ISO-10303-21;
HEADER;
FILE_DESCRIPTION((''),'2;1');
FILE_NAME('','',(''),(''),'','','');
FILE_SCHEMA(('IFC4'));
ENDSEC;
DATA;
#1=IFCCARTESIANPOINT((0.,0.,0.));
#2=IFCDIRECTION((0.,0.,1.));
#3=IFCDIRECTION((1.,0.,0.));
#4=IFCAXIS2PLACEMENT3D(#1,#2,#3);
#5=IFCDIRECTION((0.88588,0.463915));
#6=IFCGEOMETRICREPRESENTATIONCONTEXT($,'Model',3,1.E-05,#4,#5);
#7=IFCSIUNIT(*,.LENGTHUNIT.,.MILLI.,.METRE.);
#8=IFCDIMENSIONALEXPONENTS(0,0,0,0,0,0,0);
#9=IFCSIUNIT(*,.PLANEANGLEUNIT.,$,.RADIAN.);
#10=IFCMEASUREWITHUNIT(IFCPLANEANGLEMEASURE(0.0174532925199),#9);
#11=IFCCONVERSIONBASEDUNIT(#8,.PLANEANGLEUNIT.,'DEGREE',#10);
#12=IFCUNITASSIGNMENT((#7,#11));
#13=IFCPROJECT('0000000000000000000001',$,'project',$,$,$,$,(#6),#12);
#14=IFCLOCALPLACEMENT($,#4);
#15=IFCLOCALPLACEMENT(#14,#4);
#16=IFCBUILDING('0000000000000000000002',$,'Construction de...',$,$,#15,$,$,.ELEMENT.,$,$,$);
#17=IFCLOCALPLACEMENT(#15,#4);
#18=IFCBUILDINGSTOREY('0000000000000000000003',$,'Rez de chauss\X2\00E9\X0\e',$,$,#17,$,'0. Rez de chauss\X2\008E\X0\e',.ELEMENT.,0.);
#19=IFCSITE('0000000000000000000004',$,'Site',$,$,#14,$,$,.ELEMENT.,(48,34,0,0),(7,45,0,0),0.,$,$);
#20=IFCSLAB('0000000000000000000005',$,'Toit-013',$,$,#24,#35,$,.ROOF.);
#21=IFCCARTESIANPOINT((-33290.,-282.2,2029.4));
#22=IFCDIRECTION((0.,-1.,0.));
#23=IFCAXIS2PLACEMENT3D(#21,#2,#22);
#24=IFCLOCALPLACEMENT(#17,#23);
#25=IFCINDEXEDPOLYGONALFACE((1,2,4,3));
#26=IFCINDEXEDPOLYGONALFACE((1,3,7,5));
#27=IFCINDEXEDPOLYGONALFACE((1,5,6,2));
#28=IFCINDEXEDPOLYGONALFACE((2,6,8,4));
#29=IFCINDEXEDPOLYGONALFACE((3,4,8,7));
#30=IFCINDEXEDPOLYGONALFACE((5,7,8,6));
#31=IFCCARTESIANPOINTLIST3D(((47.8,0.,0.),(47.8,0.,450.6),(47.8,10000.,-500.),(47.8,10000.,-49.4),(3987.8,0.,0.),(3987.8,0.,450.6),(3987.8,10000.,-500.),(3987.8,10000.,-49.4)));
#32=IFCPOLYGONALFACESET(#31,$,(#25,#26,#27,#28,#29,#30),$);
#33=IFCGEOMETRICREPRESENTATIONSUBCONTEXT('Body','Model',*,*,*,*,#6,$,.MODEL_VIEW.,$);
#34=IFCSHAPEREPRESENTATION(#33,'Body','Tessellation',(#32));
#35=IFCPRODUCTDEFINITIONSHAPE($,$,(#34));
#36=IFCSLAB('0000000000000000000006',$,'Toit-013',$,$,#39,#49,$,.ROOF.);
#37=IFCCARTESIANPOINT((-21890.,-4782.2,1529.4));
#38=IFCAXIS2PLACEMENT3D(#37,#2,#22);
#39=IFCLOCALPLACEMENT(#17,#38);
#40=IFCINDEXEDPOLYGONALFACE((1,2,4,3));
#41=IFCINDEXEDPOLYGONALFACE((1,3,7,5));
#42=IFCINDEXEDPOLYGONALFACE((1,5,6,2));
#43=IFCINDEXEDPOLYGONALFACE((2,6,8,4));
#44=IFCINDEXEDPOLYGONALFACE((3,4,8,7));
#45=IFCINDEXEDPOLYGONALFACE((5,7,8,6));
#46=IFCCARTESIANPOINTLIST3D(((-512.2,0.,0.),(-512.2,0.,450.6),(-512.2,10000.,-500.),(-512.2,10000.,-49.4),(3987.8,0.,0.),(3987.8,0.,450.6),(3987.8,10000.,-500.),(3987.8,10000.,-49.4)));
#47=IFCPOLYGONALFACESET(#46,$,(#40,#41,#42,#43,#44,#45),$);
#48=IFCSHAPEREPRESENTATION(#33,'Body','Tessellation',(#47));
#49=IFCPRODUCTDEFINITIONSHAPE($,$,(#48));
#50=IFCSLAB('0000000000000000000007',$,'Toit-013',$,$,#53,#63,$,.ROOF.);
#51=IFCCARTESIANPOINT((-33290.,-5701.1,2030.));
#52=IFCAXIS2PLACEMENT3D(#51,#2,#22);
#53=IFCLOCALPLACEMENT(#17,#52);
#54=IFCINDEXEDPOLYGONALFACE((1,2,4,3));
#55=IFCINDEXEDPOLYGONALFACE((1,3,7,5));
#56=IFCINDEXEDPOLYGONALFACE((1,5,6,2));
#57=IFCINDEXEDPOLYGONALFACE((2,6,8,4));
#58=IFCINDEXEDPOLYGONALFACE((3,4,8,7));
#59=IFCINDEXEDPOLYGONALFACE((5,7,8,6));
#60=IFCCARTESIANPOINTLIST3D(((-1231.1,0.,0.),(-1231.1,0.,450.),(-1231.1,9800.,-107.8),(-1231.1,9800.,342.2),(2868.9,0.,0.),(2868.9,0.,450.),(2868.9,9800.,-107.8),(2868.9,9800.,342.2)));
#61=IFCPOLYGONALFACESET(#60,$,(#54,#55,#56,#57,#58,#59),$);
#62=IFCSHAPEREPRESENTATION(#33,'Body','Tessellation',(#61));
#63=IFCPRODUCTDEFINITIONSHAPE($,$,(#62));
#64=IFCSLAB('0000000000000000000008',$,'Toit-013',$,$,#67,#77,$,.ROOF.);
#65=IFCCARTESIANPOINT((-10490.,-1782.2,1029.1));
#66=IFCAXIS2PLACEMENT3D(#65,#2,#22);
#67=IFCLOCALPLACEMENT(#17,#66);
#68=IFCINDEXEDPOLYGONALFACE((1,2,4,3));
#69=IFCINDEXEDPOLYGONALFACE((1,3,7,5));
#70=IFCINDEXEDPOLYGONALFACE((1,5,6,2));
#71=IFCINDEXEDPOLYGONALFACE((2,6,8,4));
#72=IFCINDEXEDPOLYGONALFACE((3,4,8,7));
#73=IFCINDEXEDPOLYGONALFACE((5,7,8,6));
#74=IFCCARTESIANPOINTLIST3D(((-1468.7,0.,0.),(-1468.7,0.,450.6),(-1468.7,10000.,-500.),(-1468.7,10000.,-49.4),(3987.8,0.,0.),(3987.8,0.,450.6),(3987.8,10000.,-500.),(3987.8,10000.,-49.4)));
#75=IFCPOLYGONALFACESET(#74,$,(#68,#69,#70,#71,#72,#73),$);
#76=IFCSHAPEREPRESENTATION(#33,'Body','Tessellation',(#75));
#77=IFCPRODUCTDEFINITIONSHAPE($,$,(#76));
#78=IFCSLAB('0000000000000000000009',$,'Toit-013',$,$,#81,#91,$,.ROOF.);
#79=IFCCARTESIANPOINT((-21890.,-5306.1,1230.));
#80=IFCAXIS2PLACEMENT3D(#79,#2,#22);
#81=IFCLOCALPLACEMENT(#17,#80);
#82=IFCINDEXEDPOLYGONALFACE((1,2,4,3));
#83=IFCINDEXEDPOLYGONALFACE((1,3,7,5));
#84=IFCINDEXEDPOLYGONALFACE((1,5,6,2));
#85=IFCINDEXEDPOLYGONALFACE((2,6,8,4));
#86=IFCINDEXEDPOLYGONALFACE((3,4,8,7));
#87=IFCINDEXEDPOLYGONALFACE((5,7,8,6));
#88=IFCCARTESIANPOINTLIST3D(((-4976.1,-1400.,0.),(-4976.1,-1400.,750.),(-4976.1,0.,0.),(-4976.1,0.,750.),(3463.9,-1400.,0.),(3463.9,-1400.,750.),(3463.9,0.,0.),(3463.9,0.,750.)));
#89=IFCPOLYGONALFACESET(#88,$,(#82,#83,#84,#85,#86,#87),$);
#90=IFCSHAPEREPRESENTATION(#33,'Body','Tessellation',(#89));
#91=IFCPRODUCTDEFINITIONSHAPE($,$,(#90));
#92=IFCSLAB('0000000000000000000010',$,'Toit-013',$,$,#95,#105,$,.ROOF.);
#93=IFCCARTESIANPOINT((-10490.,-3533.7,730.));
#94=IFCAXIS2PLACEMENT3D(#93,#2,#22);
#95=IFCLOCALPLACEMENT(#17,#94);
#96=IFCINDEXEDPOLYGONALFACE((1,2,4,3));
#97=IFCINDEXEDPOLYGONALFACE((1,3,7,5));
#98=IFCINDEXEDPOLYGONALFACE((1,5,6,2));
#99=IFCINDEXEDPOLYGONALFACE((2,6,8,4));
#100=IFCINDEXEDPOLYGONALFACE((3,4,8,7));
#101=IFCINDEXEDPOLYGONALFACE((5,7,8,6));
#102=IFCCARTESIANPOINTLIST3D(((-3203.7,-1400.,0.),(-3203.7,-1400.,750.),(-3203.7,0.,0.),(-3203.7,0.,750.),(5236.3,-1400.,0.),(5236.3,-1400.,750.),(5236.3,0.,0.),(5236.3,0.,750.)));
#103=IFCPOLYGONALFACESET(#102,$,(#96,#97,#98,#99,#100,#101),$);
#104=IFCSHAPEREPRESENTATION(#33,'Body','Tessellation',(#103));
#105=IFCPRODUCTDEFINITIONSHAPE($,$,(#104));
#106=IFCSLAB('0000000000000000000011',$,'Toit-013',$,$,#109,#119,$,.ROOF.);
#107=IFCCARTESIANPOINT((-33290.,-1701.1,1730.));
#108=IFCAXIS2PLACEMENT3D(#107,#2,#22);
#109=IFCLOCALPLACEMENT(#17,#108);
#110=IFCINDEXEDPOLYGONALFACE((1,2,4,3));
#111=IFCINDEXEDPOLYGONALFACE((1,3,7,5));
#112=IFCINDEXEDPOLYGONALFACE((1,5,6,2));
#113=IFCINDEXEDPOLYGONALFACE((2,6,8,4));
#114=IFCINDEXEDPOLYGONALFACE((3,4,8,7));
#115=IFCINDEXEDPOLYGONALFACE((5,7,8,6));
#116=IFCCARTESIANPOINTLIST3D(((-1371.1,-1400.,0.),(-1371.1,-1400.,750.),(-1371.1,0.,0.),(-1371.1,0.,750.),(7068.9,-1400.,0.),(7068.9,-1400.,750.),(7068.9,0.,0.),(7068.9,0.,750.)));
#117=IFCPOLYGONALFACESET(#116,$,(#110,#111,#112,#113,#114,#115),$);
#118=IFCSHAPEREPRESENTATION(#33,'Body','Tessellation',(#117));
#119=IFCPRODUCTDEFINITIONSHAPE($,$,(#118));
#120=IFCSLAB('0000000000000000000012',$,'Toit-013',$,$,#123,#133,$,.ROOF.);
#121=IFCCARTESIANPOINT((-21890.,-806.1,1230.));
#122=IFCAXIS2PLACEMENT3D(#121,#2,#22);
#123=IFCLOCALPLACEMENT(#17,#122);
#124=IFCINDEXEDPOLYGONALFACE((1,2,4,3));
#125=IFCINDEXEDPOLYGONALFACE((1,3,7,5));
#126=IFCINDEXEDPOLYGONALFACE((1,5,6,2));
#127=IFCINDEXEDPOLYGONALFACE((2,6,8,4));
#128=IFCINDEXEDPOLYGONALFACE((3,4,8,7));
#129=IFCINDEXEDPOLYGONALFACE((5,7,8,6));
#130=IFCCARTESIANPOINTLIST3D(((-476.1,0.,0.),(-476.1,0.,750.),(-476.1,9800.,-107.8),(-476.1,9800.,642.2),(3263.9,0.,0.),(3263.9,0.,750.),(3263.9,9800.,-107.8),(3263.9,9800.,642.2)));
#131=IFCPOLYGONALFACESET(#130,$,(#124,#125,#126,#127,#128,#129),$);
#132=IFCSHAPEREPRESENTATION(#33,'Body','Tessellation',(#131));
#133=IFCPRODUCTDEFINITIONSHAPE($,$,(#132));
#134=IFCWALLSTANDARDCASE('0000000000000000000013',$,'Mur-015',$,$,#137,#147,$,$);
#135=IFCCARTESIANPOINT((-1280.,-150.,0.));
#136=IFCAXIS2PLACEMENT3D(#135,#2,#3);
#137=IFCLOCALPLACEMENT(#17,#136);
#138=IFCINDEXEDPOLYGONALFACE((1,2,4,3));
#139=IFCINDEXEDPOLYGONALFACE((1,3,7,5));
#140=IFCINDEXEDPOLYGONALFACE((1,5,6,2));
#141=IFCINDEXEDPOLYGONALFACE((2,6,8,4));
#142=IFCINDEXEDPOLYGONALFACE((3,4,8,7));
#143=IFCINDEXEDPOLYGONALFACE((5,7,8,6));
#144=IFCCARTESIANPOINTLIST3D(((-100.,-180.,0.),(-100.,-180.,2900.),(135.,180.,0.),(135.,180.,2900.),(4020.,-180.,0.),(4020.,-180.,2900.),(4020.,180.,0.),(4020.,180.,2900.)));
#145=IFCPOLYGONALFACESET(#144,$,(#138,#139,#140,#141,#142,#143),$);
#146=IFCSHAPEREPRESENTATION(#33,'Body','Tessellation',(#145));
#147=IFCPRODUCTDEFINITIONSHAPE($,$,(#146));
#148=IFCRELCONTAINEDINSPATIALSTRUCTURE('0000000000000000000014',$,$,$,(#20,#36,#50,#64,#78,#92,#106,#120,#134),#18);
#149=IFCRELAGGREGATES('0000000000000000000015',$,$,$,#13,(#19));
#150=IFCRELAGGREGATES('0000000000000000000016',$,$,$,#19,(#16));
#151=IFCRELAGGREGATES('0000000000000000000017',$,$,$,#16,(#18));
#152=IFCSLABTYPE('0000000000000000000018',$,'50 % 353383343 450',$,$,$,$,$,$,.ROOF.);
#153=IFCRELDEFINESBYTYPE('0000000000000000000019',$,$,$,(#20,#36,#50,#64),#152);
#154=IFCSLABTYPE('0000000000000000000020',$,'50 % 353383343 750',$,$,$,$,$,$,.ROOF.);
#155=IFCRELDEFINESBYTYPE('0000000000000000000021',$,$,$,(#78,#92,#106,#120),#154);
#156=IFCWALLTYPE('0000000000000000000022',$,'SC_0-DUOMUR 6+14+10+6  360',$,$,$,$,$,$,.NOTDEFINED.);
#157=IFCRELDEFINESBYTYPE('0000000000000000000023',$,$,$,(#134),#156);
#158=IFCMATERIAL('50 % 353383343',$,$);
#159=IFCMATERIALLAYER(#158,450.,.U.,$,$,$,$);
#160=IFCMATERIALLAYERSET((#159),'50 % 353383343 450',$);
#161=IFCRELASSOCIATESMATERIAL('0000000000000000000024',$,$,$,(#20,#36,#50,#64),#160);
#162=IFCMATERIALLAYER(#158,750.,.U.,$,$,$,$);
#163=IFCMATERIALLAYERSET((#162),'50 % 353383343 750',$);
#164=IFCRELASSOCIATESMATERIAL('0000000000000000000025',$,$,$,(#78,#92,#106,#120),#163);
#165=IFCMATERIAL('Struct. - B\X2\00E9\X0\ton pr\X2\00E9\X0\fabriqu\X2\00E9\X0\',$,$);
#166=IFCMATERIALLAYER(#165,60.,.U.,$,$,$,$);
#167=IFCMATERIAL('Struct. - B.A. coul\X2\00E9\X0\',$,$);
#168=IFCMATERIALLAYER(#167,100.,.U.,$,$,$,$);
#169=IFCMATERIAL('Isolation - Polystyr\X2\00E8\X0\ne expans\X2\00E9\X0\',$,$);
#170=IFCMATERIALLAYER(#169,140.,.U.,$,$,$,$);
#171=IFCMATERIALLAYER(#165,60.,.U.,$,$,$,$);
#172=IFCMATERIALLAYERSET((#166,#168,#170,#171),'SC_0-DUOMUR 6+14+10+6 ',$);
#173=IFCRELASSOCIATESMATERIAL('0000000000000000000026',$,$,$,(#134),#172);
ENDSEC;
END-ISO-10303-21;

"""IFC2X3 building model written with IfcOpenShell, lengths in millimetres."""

from ifc_helpers import new_model, entity, si_unit, converted_unit, direction, frame, origin_with_axes, place, context, subcontext, project, spatial, polyline, outline, extrude, clip, halfspace, material, layer, layer_set, layer_usage, type_object, element, save


model = new_model("IFC2X3")

# Units and contexts
model_context = context("Model", 3, precision=1e-05, world=origin_with_axes(), true_north=direction((0.88588, 0.463915)))
body_context = subcontext(model_context, "Body", "Model", "MODEL_VIEW")
ifc_project = project(units=[si_unit("LENGTHUNIT", "METRE", prefix="MILLI"), converted_unit("PLANEANGLEUNIT", "DEGREE", entity("IfcPlaneAngleMeasure", 0.0174532925199), si_unit("PLANEANGLEUNIT", "RADIAN"), dimensions=[0, 0, 0, 0, 0, 0, 0])], contexts=[model_context])

# Site, building, storey
site_placement = place(None, origin_with_axes())
site = spatial("IfcSite", under=ifc_project, at=site_placement, Name="Site", CompositionType="ELEMENT", RefLatitude=(48, 34, 0, 0), RefLongitude=(7, 45, 0, 0), RefElevation=0.0)
building_placement = place(site_placement, origin_with_axes())
building = spatial("IfcBuilding", under=site, at=building_placement, Name="Construction de...", CompositionType="ELEMENT")
storey_placement = place(building_placement, origin_with_axes())
storey = spatial("IfcBuildingStorey", under=building, at=storey_placement, Name="Rez de chaussée", LongName="0. Rez de chauss\u008ee", CompositionType="ELEMENT", Elevation=0.0)

# Slabs
ifc_material_1 = material(Name="50 % 353383343")
ifc_layer_1 = layer(ifc_material_1, 450.0, ventilated="UNKNOWN")
ifc_layer_set_1 = layer_set([ifc_layer_1], Name="50 % 353383343 450")
ifc_layer_usage_1 = layer_usage(ifc_layer_set_1, "AXIS3", "NEGATIVE", 450.0)
slab_type_1 = type_object("IfcSlabType", Name="50 % 353383343 450", PredefinedType="ROOF")
slab_1_placement = place(storey_placement, frame((-33290.0, -282.2, 2029.4), z_axis=(0.0, 0.0, 1.0), x_axis=(0.0, -1.0, 0.0)))
element("IfcSlab", 1, at=slab_1_placement, inside=storey, type_object=slab_type_1, material=ifc_layer_usage_1, Name="Toit-013", PredefinedType="ROOF", context=body_context, shape_type="SweptSolid", body=[
    extrude(outline(polyline([(3987.8, 0.0), (3987.8, 10012.5), (47.8, 10012.5), (47.8, 0.0), (3987.8, 0.0)])), frame((0.0, 0.0, 0.0), z_axis=(0.0, 0.049938, 0.998752), x_axis=(1.0, 0.0, 0.0)), (0.0, -0.049938, 0.998752), 450.6),
])
ifc_layer_usage_2 = layer_usage(ifc_layer_set_1, "AXIS3", "NEGATIVE", 450.0)
slab_2_placement = place(storey_placement, frame((-21890.0, -4782.2, 1529.4), z_axis=(0.0, 0.0, 1.0), x_axis=(0.0, -1.0, 0.0)))
element("IfcSlab", 2, at=slab_2_placement, inside=storey, type_object=slab_type_1, material=ifc_layer_usage_2, Name="Toit-013", PredefinedType="ROOF", context=body_context, shape_type="SweptSolid", body=[
    extrude(outline(polyline([(3987.8, 0.0), (3987.8, 10012.5), (-512.2, 10012.5), (-512.2, 0.0), (3987.8, 0.0)])), frame((0.0, 0.0, 0.0), z_axis=(0.0, 0.049938, 0.998752), x_axis=(1.0, 0.0, 0.0)), (0.0, -0.049938, 0.998752), 450.6),
])
ifc_layer_usage_3 = layer_usage(ifc_layer_set_1, "AXIS3", "NEGATIVE", 450.0)
slab_3_placement = place(storey_placement, frame((-33290.0, -5701.1, 2030.0), z_axis=(0.0, 0.0, 1.0), x_axis=(0.0, -1.0, 0.0)))
element("IfcSlab", 3, at=slab_3_placement, inside=storey, type_object=slab_type_1, material=ifc_layer_usage_3, Name="Toit-013", PredefinedType="ROOF", context=body_context, shape_type="SweptSolid", body=[
    extrude(outline(polyline([(-1231.1, 9800.6), (-1231.1, 0.0), (2868.9, 0.0), (2868.9, 9800.6), (-1231.1, 9800.6)])), frame((0.0, 0.0, 0.0), z_axis=(0.0, 0.010999, 0.99994), x_axis=(1.0, 0.0, 0.0)), (0.0, -0.010999, 0.99994), 450.0),
])
ifc_layer_usage_4 = layer_usage(ifc_layer_set_1, "AXIS3", "NEGATIVE", 450.0)
slab_4_placement = place(storey_placement, frame((-10490.0, -1782.2, 1029.1), z_axis=(0.0, 0.0, 1.0), x_axis=(0.0, -1.0, 0.0)))
element("IfcSlab", 4, at=slab_4_placement, inside=storey, type_object=slab_type_1, material=ifc_layer_usage_4, Name="Toit-013", PredefinedType="ROOF", context=body_context, shape_type="SweptSolid", body=[
    extrude(outline(polyline([(3987.8, 0.0), (3987.8, 10012.5), (-1468.7, 10012.5), (-1468.7, 0.0), (3987.8, 0.0)])), frame((0.0, 0.0, 0.0), z_axis=(0.0, 0.049938, 0.998752), x_axis=(1.0, 0.0, 0.0)), (0.0, -0.049938, 0.998752), 450.6),
])
ifc_layer_2 = layer(ifc_material_1, 750.0, ventilated="UNKNOWN")
ifc_layer_set_2 = layer_set([ifc_layer_2], Name="50 % 353383343 750")
ifc_layer_usage_5 = layer_usage(ifc_layer_set_2, "AXIS3", "NEGATIVE", 750.0)
slab_type_2 = type_object("IfcSlabType", Name="50 % 353383343 750", PredefinedType="ROOF")
slab_5_placement = place(storey_placement, frame((-21890.0, -5306.1, 1230.0), z_axis=(0.0, 0.0, 1.0), x_axis=(0.0, -1.0, 0.0)))
element("IfcSlab", 5, at=slab_5_placement, inside=storey, type_object=slab_type_2, material=ifc_layer_usage_5, Name="Toit-013", PredefinedType="ROOF", context=body_context, shape_type="SweptSolid", body=[
    extrude(outline(polyline([(-4976.1, 0.0), (-4976.1, -1400.0), (3463.9, -1400.0), (3463.9, 0.0), (-4976.1, 0.0)])), origin_with_axes(), (0.0, 0.0, 1.0), 750.0),
])
ifc_layer_usage_6 = layer_usage(ifc_layer_set_2, "AXIS3", "NEGATIVE", 750.0)
slab_6_placement = place(storey_placement, frame((-10490.0, -3533.7, 730.0), z_axis=(0.0, 0.0, 1.0), x_axis=(0.0, -1.0, 0.0)))
element("IfcSlab", 6, at=slab_6_placement, inside=storey, type_object=slab_type_2, material=ifc_layer_usage_6, Name="Toit-013", PredefinedType="ROOF", context=body_context, shape_type="SweptSolid", body=[
    extrude(outline(polyline([(-3203.7, 0.0), (-3203.7, -1400.0), (5236.3, -1400.0), (5236.3, 0.0), (-3203.7, 0.0)])), origin_with_axes(), (0.0, 0.0, 1.0), 750.0),
])
ifc_layer_usage_7 = layer_usage(ifc_layer_set_2, "AXIS3", "NEGATIVE", 750.0)
slab_7_placement = place(storey_placement, frame((-33290.0, -1701.1, 1730.0), z_axis=(0.0, 0.0, 1.0), x_axis=(0.0, -1.0, 0.0)))
element("IfcSlab", 7, at=slab_7_placement, inside=storey, type_object=slab_type_2, material=ifc_layer_usage_7, Name="Toit-013", PredefinedType="ROOF", context=body_context, shape_type="SweptSolid", body=[
    extrude(outline(polyline([(-1371.1, 0.0), (-1371.1, -1400.0), (7068.9, -1400.0), (7068.9, 0.0), (-1371.1, 0.0)])), origin_with_axes(), (0.0, 0.0, 1.0), 750.0),
])
ifc_layer_usage_8 = layer_usage(ifc_layer_set_2, "AXIS3", "NEGATIVE", 750.0)
slab_8_placement = place(storey_placement, frame((-21890.0, -806.1, 1230.0), z_axis=(0.0, 0.0, 1.0), x_axis=(0.0, -1.0, 0.0)))
element("IfcSlab", 8, at=slab_8_placement, inside=storey, type_object=slab_type_2, material=ifc_layer_usage_8, Name="Toit-013", PredefinedType="ROOF", context=body_context, shape_type="SweptSolid", body=[
    extrude(outline(polyline([(3263.9, 0.0), (3263.9, 9800.6), (-476.1, 9800.6), (-476.1, 0.0), (3263.9, 0.0)])), frame((0.0, 0.0, 0.0), z_axis=(0.0, 0.010999, 0.99994), x_axis=(1.0, 0.0, 0.0)), (0.0, -0.010999, 0.99994), 750.0),
])

# Wall
ifc_material_2 = material(Name="Struct. - Béton préfabriqué")
ifc_layer_3 = layer(ifc_material_2, 60.0, ventilated="UNKNOWN")
ifc_material_3 = material(Name="Struct. - B.A. coulé")
ifc_layer_4 = layer(ifc_material_3, 100.0, ventilated="UNKNOWN")
ifc_material_4 = material(Name="Isolation - Polystyrène expansé")
ifc_layer_5 = layer(ifc_material_4, 140.0, ventilated="UNKNOWN")
ifc_layer_6 = layer(ifc_material_2, 60.0, ventilated="UNKNOWN")
ifc_layer_set_3 = layer_set([ifc_layer_3, ifc_layer_4, ifc_layer_5, ifc_layer_6], Name="SC_0-DUOMUR 6+14+10+6 ")
ifc_layer_usage_9 = layer_usage(ifc_layer_set_3, "AXIS2", "NEGATIVE", 180.0)
wall_type_1 = type_object("IfcWallType", Name="SC_0-DUOMUR 6+14+10+6  360", PredefinedType="NOTDEFINED")
wall_1_placement = place(storey_placement, frame((-1280.0, -150.0, 0.0), z_axis=(0.0, 0.0, 1.0), x_axis=(1.0, 0.0, 0.0)))
element("IfcWallStandardCase", 9, at=wall_1_placement, inside=storey, type_object=wall_type_1, material=ifc_layer_usage_9, Name="Mur-015", context=body_context, shape_type="Clipping", body=[
    clip(extrude(outline(polyline([(-100.0, -180.0), (4020.0, -180.0), (4020.0, 180.0), (135.0, 180.0), (-100.0, -180.0)])), origin_with_axes(), (0.0, 0.0, 1.0), 2900.0), halfspace(frame((-198.2, 0.0, 5285.8), z_axis=(0.037474, 0.0, -0.999298), x_axis=(0.0, 1.0, 0.0)), True)),
])

save(model, "model.ifc")
